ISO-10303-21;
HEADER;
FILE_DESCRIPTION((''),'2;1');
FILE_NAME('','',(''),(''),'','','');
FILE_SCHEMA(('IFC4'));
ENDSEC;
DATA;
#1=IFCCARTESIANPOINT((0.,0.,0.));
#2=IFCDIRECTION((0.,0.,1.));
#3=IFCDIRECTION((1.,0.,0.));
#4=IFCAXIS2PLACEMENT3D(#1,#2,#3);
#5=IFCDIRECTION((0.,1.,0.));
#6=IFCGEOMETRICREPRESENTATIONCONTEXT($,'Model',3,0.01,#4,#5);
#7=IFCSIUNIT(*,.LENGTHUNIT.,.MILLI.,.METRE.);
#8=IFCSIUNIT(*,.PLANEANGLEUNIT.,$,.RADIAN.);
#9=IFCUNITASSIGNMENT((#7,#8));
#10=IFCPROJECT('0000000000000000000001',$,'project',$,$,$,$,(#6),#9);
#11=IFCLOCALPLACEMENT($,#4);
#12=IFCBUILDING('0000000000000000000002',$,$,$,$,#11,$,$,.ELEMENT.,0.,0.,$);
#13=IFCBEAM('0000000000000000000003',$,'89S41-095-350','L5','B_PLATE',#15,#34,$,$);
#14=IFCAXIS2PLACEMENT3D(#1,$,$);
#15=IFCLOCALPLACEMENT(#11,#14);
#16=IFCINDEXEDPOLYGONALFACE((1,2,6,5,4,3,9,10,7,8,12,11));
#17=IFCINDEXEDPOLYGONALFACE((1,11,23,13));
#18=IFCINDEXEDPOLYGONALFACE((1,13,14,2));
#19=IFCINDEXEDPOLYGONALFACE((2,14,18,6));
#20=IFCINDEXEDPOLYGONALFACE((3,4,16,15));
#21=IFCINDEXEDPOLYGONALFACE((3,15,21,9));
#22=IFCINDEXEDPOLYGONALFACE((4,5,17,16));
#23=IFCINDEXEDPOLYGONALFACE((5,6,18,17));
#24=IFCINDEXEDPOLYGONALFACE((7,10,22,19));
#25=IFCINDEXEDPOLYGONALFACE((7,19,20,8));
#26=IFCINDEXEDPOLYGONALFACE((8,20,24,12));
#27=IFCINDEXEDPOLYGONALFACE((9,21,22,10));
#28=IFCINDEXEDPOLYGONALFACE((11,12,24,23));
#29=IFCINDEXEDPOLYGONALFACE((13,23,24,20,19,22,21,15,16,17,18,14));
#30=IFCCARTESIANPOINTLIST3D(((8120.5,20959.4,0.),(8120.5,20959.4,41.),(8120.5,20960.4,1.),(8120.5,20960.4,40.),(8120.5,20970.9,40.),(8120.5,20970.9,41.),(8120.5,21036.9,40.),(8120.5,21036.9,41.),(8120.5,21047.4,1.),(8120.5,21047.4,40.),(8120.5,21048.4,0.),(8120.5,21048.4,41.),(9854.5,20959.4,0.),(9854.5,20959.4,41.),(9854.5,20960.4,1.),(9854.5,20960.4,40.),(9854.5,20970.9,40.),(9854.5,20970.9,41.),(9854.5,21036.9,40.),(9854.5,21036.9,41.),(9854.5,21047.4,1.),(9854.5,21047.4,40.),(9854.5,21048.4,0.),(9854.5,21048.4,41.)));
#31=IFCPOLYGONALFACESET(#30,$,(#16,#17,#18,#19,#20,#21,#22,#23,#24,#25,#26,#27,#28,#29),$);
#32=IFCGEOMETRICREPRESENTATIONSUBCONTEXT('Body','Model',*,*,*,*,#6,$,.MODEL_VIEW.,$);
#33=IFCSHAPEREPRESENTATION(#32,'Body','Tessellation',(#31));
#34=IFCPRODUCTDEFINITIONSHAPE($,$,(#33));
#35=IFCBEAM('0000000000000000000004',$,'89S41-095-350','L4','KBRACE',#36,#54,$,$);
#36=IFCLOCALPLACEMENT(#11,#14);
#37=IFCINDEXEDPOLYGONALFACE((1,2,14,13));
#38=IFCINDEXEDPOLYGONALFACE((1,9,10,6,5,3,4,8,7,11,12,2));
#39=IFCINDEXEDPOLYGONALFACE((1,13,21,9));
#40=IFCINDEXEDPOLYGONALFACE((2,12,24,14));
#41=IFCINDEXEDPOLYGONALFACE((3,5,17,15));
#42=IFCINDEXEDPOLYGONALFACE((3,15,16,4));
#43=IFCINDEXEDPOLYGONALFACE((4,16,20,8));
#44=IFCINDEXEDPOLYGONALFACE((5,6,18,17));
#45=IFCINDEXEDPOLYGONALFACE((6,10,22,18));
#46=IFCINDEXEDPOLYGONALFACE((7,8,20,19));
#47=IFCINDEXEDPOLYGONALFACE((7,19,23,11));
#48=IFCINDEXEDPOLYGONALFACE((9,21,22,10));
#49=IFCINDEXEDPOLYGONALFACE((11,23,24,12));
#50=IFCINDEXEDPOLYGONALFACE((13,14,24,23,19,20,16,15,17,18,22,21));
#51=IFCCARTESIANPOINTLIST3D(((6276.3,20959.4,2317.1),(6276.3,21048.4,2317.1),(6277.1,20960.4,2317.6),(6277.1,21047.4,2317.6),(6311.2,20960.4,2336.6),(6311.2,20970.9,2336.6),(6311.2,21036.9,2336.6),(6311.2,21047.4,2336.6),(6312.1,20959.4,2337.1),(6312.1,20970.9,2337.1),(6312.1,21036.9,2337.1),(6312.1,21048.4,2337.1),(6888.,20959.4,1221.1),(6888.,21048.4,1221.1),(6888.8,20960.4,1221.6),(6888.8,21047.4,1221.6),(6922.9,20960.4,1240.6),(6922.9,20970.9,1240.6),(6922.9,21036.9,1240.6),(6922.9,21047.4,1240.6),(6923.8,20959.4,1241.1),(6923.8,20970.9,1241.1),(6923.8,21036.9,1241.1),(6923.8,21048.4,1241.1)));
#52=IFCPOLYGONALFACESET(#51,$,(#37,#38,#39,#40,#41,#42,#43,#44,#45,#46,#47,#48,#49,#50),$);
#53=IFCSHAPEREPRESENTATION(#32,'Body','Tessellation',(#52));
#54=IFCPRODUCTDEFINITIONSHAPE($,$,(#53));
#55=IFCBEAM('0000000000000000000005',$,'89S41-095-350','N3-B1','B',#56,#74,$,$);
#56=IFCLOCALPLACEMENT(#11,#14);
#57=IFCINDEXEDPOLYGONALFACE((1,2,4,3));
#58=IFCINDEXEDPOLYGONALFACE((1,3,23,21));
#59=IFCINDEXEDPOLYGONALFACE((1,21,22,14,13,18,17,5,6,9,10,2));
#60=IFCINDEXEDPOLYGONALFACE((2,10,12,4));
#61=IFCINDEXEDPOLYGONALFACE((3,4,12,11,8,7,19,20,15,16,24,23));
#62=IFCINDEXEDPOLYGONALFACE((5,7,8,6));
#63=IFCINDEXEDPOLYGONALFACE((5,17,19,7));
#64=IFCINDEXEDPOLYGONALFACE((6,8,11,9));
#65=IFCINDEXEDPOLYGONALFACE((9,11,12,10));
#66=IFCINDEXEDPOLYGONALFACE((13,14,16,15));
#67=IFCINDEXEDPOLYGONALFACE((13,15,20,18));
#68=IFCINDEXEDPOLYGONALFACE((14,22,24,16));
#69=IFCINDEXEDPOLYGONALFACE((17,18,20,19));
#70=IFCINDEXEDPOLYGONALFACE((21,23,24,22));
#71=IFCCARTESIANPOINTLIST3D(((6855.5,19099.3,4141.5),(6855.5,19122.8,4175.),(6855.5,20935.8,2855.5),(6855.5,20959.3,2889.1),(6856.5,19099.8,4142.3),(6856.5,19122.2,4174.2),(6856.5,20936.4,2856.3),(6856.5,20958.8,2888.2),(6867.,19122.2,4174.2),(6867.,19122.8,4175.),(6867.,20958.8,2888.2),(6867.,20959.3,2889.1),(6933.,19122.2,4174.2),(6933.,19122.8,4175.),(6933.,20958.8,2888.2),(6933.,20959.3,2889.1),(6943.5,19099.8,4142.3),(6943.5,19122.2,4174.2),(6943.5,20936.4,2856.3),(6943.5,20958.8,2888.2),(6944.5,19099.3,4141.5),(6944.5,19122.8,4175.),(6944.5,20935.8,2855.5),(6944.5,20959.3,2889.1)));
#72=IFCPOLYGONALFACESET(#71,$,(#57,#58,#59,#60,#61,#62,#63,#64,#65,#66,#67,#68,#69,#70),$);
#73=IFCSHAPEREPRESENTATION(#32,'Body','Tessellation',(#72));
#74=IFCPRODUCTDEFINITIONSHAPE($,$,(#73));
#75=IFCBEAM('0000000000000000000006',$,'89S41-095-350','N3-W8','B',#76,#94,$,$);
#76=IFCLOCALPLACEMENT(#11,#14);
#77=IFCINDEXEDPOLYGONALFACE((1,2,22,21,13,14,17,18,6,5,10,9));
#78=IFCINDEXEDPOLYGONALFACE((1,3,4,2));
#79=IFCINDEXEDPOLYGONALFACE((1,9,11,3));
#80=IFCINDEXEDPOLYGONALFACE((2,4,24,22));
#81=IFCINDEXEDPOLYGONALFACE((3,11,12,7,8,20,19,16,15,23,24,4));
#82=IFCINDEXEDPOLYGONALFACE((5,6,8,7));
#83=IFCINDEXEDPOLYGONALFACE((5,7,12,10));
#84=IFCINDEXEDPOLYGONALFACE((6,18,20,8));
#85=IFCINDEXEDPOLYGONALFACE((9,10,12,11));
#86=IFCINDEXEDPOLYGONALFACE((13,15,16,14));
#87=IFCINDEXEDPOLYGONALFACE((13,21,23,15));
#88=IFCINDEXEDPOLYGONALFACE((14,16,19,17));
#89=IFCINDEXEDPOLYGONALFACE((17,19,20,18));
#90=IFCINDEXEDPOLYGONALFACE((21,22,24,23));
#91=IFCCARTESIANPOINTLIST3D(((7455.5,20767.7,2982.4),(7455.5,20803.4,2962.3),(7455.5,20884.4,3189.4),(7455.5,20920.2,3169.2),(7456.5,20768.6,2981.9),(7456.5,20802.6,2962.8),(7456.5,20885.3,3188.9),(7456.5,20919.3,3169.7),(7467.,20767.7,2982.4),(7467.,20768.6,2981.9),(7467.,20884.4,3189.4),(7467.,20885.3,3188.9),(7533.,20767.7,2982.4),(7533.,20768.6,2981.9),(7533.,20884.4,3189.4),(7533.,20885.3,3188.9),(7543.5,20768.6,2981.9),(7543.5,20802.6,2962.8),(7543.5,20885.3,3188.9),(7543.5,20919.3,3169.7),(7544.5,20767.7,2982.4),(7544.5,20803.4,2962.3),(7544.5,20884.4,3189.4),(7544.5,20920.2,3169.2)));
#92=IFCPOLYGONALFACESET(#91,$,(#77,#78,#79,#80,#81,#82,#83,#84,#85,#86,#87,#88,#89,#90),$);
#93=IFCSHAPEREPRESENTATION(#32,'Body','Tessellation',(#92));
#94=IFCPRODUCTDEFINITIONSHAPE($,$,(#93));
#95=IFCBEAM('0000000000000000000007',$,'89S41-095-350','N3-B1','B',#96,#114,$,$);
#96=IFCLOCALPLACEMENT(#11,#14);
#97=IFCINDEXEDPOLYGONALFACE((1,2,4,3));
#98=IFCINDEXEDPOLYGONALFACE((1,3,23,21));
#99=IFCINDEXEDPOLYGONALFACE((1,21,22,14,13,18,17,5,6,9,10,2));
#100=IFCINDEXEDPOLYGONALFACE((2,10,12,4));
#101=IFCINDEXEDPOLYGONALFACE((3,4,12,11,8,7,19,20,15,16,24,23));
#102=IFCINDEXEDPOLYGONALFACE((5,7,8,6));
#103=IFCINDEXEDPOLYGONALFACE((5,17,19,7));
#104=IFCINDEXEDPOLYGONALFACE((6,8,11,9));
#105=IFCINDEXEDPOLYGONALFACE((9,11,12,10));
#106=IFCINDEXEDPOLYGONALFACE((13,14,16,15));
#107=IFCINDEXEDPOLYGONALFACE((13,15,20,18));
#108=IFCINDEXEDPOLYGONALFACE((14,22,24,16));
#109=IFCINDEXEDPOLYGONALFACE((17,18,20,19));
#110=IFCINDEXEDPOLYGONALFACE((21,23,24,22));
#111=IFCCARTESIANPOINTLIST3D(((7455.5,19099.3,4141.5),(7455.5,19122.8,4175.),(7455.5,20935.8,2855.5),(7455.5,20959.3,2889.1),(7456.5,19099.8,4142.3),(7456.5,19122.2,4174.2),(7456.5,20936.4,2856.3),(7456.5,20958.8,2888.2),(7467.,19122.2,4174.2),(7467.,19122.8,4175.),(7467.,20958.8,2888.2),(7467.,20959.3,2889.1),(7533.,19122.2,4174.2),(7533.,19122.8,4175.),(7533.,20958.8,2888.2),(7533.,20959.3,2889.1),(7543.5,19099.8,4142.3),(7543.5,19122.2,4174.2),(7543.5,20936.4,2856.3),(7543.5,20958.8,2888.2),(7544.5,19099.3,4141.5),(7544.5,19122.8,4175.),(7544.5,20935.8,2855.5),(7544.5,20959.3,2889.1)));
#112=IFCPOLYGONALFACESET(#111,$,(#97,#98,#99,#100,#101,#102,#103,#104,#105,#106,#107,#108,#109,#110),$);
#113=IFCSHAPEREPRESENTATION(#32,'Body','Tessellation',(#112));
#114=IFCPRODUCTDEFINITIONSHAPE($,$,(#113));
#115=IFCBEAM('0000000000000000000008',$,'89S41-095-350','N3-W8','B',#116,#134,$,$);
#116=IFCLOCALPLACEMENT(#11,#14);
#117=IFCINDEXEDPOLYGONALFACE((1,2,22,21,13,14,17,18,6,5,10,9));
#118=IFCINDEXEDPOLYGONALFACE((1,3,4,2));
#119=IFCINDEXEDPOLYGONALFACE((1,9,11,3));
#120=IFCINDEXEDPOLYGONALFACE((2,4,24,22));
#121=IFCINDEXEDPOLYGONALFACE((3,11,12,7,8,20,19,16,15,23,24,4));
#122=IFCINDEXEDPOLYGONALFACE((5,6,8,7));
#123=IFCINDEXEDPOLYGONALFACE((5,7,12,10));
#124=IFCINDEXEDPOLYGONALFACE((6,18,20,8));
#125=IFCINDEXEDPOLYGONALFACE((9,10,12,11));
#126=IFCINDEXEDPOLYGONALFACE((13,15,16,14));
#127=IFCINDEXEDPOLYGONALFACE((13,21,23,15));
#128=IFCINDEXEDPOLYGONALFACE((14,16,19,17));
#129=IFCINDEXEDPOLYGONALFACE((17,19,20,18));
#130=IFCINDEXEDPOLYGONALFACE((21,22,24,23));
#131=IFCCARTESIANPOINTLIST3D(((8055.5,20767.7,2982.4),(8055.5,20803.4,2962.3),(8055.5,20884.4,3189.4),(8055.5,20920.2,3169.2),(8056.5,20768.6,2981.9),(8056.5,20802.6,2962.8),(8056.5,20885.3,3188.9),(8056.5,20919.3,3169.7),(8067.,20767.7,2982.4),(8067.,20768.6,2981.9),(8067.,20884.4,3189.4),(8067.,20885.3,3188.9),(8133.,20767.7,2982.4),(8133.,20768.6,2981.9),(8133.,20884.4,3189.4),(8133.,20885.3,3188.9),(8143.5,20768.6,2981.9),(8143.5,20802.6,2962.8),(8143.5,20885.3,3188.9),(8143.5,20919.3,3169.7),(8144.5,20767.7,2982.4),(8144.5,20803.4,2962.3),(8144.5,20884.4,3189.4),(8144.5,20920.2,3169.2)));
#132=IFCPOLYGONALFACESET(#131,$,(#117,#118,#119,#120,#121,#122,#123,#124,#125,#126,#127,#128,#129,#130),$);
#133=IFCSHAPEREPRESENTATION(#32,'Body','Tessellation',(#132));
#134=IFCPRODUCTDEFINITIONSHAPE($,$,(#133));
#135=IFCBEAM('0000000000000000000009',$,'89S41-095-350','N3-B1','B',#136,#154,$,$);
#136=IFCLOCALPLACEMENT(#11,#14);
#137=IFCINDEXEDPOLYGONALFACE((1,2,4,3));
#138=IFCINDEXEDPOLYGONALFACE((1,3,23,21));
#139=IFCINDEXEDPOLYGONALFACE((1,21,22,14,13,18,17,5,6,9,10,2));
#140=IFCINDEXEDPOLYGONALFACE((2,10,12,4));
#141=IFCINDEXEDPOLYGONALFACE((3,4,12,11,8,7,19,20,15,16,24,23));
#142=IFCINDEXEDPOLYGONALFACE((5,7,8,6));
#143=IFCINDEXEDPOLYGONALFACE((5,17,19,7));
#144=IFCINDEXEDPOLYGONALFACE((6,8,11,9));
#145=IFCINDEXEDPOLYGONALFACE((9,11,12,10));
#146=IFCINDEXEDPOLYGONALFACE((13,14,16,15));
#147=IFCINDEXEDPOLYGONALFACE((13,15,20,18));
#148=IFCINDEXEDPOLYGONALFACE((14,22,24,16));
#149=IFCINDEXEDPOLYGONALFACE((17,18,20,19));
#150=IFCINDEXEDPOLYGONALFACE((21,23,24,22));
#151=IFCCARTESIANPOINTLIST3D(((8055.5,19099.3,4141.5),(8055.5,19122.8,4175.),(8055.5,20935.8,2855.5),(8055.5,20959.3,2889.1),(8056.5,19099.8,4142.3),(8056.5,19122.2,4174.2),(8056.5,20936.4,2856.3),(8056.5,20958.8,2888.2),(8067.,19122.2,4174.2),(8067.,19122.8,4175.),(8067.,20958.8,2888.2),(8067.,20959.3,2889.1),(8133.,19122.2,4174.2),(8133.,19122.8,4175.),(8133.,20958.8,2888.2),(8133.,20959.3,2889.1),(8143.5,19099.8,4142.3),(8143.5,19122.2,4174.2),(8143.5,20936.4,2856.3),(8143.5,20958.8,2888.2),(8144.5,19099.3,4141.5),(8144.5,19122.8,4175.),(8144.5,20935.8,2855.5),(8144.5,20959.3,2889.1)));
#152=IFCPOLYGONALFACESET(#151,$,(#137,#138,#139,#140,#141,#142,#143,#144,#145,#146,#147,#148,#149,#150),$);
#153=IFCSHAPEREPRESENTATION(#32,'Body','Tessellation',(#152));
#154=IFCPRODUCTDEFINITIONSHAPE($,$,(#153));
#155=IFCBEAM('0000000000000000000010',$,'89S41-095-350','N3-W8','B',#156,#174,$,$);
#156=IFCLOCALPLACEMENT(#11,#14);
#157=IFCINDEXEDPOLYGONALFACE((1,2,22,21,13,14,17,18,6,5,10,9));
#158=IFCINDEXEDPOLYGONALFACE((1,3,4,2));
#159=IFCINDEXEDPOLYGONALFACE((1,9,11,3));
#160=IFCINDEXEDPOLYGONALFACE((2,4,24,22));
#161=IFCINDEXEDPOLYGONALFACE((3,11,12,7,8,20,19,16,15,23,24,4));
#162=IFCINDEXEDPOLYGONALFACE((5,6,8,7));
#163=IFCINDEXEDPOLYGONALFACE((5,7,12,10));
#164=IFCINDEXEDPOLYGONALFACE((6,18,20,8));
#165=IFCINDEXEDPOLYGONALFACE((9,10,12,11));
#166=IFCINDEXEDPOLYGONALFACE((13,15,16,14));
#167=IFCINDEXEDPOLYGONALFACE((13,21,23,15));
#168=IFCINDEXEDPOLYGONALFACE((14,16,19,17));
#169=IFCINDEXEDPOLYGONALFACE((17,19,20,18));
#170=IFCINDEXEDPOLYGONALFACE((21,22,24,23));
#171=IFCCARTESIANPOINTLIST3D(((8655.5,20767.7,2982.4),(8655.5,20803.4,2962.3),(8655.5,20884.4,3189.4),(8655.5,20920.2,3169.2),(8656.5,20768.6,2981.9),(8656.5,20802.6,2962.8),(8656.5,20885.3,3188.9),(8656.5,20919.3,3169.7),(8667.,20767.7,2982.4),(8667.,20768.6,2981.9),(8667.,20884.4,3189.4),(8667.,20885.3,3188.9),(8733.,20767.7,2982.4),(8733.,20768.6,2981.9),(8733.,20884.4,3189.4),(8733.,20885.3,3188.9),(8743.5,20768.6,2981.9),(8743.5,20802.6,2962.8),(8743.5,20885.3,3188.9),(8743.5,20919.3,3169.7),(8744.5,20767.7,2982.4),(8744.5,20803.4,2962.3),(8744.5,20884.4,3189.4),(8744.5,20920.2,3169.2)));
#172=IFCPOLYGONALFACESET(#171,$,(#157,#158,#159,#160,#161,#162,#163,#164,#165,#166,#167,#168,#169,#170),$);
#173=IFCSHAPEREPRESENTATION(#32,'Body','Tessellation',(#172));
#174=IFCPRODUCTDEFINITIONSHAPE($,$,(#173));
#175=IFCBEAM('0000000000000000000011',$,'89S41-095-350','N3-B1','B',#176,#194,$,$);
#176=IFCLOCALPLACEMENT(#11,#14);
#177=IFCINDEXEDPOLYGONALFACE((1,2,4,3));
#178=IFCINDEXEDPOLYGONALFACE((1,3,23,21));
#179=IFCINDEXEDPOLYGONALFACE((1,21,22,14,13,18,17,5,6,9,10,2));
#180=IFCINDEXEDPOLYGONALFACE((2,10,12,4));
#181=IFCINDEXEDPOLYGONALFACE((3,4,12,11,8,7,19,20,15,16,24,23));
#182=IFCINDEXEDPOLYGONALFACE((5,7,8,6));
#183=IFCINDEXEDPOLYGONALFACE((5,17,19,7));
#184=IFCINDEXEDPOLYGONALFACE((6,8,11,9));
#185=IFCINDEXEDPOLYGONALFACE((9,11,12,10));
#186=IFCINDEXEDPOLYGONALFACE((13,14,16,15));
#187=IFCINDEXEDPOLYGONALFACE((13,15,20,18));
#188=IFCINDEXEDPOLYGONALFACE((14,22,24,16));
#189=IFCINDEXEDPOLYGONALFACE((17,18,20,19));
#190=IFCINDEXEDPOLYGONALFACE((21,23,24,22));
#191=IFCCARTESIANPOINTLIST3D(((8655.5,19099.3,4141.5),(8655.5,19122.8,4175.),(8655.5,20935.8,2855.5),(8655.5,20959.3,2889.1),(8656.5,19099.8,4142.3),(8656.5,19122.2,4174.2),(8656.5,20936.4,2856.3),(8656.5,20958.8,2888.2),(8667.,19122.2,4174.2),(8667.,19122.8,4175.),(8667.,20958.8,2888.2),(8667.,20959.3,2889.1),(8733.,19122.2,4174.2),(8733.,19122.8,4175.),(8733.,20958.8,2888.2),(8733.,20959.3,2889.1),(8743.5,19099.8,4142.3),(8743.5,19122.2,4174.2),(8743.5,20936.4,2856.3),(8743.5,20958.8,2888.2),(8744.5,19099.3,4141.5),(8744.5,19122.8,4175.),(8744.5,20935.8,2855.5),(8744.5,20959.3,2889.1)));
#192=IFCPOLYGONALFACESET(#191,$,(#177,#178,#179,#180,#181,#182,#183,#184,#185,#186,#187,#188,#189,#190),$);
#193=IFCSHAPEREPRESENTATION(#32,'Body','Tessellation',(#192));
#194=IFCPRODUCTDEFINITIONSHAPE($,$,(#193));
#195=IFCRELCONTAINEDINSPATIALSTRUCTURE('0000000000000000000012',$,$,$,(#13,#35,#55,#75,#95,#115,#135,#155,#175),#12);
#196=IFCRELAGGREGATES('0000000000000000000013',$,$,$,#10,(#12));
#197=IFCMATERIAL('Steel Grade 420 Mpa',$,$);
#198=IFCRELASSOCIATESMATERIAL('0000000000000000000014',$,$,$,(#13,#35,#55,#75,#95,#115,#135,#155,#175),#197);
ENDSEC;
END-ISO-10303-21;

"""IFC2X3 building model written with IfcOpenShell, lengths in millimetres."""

from ifc_helpers import new_model, si_unit, direction, frame, origin, origin_with_axes, origin_2d_with_axis, place, context, subcontext, project, spatial, c_section, extrude, source, transform, mapped, material, element, save


model = new_model("IFC2X3")

# Units and contexts
model_context = context("Model", 3, precision=0.01, world=origin_with_axes(), true_north=direction((0.0, 1.0, 0.0)))
body_context = subcontext(model_context, "Body", "Model", "MODEL_VIEW")
ifc_project = project(units=[si_unit("LENGTHUNIT", "METRE", prefix="MILLI"), si_unit("PLANEANGLEUNIT", "RADIAN")], contexts=[model_context])

# Building
building_placement = place(None, origin_with_axes())
building = spatial("IfcBuilding", under=ifc_project, at=building_placement, CompositionType="ELEMENT", ElevationOfRefHeight=0.0, ElevationOfTerrain=0.0)

# Shared definitions
ifc_material = material(Name="Steel Grade 420 Mpa")

# Beams
shared_shape_1 = source(origin(), body_context, "Body", "SweptSolid", [
    extrude(c_section(Depth=89.0, Width=41.0, WallThickness=1.0, Girth=11.5, at=origin_2d_with_axis()), origin_with_axes(), (0.0, 0.0, 1.0), 1734.0),
])
beam_1_placement = place(None, frame((8120.5, 21003.9, 20.5), z_axis=(1.0, 0.0, 0.0), x_axis=(0.0, 0.0, 1.0)))
element("IfcBeam", 1, at=beam_1_placement, inside=building, material=ifc_material, Name="89S41-095-350", Description="L5", ObjectType="B_PLATE", context=body_context, shape_type="MappedRepresentation", body=[
    mapped(shared_shape_1, transform((0.0, 0.0, 0.0), scale=1.0)),
])
shared_shape_2 = source(origin(), body_context, "Body", "SweptSolid", [
    extrude(c_section(Depth=89.0, Width=41.0, WallThickness=1.0, Girth=11.5, at=origin_2d_with_axis()), origin_with_axes(), (0.0, 0.0, 1.0), 1255.1),
])
beam_2_placement = place(None, frame((6905.9, 21003.9, 1231.1), z_axis=(-0.487366, 0.0, 0.873198), x_axis=(0.873198, 0.0, 0.487366)))
element("IfcBeam", 2, at=beam_2_placement, inside=building, material=ifc_material, Name="89S41-095-350", Description="L4", ObjectType="KBRACE", context=body_context, shape_type="MappedRepresentation", body=[
    mapped(shared_shape_2, transform((0.0, 0.0, 0.0), scale=1.0)),
])
shared_shape_3 = source(origin(), body_context, "Body", "SweptSolid", [
    extrude(c_section(Depth=89.0, Width=41.0, WallThickness=1.0, Girth=11.5, at=origin_2d_with_axis()), origin_with_axes(), (0.0, 0.0, 1.0), 2242.0),
])
beam_3_placement = place(None, frame((6900.0, 20947.6, 2872.3), z_axis=(0.0, -0.819152, 0.573576), x_axis=(0.0, 0.573576, 0.819152)))
element("IfcBeam", 3, at=beam_3_placement, inside=building, material=ifc_material, Name="89S41-095-350", Description="N3-B1", ObjectType="B", context=body_context, shape_type="MappedRepresentation", body=[
    mapped(shared_shape_3, transform((0.0, 0.0, 0.0), scale=1.0)),
])
shared_shape_4 = source(origin(), body_context, "Body", "SweptSolid", [
    extrude(c_section(Depth=89.0, Width=41.0, WallThickness=1.0, Girth=11.5, at=origin_2d_with_axis()), origin_with_axes(), (0.0, 0.0, 1.0), 237.6),
])
beam_4_placement = place(None, frame((7500.0, 20902.3, 3179.3), z_axis=(0.0, -0.491169, -0.871064), x_axis=(0.0, -0.871064, 0.491169)))
element("IfcBeam", 4, at=beam_4_placement, inside=building, material=ifc_material, Name="89S41-095-350", Description="N3-W8", ObjectType="B", context=body_context, shape_type="MappedRepresentation", body=[
    mapped(shared_shape_4, transform((0.0, 0.0, 0.0), scale=1.0)),
])
shared_shape_5 = source(origin(), body_context, "Body", "SweptSolid", [
    extrude(c_section(Depth=89.0, Width=41.0, WallThickness=1.0, Girth=11.5, at=origin_2d_with_axis()), origin_with_axes(), (0.0, 0.0, 1.0), 2242.0),
])
beam_5_placement = place(None, frame((7500.0, 20947.6, 2872.3), z_axis=(0.0, -0.819152, 0.573576), x_axis=(0.0, 0.573576, 0.819152)))
element("IfcBeam", 5, at=beam_5_placement, inside=building, material=ifc_material, Name="89S41-095-350", Description="N3-B1", ObjectType="B", context=body_context, shape_type="MappedRepresentation", body=[
    mapped(shared_shape_5, transform((0.0, 0.0, 0.0), scale=1.0)),
])
shared_shape_6 = source(origin(), body_context, "Body", "SweptSolid", [
    extrude(c_section(Depth=89.0, Width=41.0, WallThickness=1.0, Girth=11.5, at=origin_2d_with_axis()), origin_with_axes(), (0.0, 0.0, 1.0), 237.6),
])
beam_6_placement = place(None, frame((8100.0, 20902.3, 3179.3), z_axis=(0.0, -0.491169, -0.871064), x_axis=(0.0, -0.871064, 0.491169)))
element("IfcBeam", 6, at=beam_6_placement, inside=building, material=ifc_material, Name="89S41-095-350", Description="N3-W8", ObjectType="B", context=body_context, shape_type="MappedRepresentation", body=[
    mapped(shared_shape_6, transform((0.0, 0.0, 0.0), scale=1.0)),
])
shared_shape_7 = source(origin(), body_context, "Body", "SweptSolid", [
    extrude(c_section(Depth=89.0, Width=41.0, WallThickness=1.0, Girth=11.5, at=origin_2d_with_axis()), origin_with_axes(), (0.0, 0.0, 1.0), 2242.0),
])
beam_7_placement = place(None, frame((8100.0, 20947.6, 2872.3), z_axis=(0.0, -0.819152, 0.573576), x_axis=(0.0, 0.573576, 0.819152)))
element("IfcBeam", 7, at=beam_7_placement, inside=building, material=ifc_material, Name="89S41-095-350", Description="N3-B1", ObjectType="B", context=body_context, shape_type="MappedRepresentation", body=[
    mapped(shared_shape_7, transform((0.0, 0.0, 0.0), scale=1.0)),
])
shared_shape_8 = source(origin(), body_context, "Body", "SweptSolid", [
    extrude(c_section(Depth=89.0, Width=41.0, WallThickness=1.0, Girth=11.5, at=origin_2d_with_axis()), origin_with_axes(), (0.0, 0.0, 1.0), 237.6),
])
beam_8_placement = place(None, frame((8700.0, 20902.3, 3179.3), z_axis=(0.0, -0.491169, -0.871064), x_axis=(0.0, -0.871064, 0.491169)))
element("IfcBeam", 8, at=beam_8_placement, inside=building, material=ifc_material, Name="89S41-095-350", Description="N3-W8", ObjectType="B", context=body_context, shape_type="MappedRepresentation", body=[
    mapped(shared_shape_8, transform((0.0, 0.0, 0.0), scale=1.0)),
])
shared_shape_9 = source(origin(), body_context, "Body", "SweptSolid", [
    extrude(c_section(Depth=89.0, Width=41.0, WallThickness=1.0, Girth=11.5, at=origin_2d_with_axis()), origin_with_axes(), (0.0, 0.0, 1.0), 2242.0),
])
beam_9_placement = place(None, frame((8700.0, 20947.6, 2872.3), z_axis=(0.0, -0.819152, 0.573576), x_axis=(0.0, 0.573576, 0.819152)))
element("IfcBeam", 9, at=beam_9_placement, inside=building, material=ifc_material, Name="89S41-095-350", Description="N3-B1", ObjectType="B", context=body_context, shape_type="MappedRepresentation", body=[
    mapped(shared_shape_9, transform((0.0, 0.0, 0.0), scale=1.0)),
])

save(model, "model.ifc")
